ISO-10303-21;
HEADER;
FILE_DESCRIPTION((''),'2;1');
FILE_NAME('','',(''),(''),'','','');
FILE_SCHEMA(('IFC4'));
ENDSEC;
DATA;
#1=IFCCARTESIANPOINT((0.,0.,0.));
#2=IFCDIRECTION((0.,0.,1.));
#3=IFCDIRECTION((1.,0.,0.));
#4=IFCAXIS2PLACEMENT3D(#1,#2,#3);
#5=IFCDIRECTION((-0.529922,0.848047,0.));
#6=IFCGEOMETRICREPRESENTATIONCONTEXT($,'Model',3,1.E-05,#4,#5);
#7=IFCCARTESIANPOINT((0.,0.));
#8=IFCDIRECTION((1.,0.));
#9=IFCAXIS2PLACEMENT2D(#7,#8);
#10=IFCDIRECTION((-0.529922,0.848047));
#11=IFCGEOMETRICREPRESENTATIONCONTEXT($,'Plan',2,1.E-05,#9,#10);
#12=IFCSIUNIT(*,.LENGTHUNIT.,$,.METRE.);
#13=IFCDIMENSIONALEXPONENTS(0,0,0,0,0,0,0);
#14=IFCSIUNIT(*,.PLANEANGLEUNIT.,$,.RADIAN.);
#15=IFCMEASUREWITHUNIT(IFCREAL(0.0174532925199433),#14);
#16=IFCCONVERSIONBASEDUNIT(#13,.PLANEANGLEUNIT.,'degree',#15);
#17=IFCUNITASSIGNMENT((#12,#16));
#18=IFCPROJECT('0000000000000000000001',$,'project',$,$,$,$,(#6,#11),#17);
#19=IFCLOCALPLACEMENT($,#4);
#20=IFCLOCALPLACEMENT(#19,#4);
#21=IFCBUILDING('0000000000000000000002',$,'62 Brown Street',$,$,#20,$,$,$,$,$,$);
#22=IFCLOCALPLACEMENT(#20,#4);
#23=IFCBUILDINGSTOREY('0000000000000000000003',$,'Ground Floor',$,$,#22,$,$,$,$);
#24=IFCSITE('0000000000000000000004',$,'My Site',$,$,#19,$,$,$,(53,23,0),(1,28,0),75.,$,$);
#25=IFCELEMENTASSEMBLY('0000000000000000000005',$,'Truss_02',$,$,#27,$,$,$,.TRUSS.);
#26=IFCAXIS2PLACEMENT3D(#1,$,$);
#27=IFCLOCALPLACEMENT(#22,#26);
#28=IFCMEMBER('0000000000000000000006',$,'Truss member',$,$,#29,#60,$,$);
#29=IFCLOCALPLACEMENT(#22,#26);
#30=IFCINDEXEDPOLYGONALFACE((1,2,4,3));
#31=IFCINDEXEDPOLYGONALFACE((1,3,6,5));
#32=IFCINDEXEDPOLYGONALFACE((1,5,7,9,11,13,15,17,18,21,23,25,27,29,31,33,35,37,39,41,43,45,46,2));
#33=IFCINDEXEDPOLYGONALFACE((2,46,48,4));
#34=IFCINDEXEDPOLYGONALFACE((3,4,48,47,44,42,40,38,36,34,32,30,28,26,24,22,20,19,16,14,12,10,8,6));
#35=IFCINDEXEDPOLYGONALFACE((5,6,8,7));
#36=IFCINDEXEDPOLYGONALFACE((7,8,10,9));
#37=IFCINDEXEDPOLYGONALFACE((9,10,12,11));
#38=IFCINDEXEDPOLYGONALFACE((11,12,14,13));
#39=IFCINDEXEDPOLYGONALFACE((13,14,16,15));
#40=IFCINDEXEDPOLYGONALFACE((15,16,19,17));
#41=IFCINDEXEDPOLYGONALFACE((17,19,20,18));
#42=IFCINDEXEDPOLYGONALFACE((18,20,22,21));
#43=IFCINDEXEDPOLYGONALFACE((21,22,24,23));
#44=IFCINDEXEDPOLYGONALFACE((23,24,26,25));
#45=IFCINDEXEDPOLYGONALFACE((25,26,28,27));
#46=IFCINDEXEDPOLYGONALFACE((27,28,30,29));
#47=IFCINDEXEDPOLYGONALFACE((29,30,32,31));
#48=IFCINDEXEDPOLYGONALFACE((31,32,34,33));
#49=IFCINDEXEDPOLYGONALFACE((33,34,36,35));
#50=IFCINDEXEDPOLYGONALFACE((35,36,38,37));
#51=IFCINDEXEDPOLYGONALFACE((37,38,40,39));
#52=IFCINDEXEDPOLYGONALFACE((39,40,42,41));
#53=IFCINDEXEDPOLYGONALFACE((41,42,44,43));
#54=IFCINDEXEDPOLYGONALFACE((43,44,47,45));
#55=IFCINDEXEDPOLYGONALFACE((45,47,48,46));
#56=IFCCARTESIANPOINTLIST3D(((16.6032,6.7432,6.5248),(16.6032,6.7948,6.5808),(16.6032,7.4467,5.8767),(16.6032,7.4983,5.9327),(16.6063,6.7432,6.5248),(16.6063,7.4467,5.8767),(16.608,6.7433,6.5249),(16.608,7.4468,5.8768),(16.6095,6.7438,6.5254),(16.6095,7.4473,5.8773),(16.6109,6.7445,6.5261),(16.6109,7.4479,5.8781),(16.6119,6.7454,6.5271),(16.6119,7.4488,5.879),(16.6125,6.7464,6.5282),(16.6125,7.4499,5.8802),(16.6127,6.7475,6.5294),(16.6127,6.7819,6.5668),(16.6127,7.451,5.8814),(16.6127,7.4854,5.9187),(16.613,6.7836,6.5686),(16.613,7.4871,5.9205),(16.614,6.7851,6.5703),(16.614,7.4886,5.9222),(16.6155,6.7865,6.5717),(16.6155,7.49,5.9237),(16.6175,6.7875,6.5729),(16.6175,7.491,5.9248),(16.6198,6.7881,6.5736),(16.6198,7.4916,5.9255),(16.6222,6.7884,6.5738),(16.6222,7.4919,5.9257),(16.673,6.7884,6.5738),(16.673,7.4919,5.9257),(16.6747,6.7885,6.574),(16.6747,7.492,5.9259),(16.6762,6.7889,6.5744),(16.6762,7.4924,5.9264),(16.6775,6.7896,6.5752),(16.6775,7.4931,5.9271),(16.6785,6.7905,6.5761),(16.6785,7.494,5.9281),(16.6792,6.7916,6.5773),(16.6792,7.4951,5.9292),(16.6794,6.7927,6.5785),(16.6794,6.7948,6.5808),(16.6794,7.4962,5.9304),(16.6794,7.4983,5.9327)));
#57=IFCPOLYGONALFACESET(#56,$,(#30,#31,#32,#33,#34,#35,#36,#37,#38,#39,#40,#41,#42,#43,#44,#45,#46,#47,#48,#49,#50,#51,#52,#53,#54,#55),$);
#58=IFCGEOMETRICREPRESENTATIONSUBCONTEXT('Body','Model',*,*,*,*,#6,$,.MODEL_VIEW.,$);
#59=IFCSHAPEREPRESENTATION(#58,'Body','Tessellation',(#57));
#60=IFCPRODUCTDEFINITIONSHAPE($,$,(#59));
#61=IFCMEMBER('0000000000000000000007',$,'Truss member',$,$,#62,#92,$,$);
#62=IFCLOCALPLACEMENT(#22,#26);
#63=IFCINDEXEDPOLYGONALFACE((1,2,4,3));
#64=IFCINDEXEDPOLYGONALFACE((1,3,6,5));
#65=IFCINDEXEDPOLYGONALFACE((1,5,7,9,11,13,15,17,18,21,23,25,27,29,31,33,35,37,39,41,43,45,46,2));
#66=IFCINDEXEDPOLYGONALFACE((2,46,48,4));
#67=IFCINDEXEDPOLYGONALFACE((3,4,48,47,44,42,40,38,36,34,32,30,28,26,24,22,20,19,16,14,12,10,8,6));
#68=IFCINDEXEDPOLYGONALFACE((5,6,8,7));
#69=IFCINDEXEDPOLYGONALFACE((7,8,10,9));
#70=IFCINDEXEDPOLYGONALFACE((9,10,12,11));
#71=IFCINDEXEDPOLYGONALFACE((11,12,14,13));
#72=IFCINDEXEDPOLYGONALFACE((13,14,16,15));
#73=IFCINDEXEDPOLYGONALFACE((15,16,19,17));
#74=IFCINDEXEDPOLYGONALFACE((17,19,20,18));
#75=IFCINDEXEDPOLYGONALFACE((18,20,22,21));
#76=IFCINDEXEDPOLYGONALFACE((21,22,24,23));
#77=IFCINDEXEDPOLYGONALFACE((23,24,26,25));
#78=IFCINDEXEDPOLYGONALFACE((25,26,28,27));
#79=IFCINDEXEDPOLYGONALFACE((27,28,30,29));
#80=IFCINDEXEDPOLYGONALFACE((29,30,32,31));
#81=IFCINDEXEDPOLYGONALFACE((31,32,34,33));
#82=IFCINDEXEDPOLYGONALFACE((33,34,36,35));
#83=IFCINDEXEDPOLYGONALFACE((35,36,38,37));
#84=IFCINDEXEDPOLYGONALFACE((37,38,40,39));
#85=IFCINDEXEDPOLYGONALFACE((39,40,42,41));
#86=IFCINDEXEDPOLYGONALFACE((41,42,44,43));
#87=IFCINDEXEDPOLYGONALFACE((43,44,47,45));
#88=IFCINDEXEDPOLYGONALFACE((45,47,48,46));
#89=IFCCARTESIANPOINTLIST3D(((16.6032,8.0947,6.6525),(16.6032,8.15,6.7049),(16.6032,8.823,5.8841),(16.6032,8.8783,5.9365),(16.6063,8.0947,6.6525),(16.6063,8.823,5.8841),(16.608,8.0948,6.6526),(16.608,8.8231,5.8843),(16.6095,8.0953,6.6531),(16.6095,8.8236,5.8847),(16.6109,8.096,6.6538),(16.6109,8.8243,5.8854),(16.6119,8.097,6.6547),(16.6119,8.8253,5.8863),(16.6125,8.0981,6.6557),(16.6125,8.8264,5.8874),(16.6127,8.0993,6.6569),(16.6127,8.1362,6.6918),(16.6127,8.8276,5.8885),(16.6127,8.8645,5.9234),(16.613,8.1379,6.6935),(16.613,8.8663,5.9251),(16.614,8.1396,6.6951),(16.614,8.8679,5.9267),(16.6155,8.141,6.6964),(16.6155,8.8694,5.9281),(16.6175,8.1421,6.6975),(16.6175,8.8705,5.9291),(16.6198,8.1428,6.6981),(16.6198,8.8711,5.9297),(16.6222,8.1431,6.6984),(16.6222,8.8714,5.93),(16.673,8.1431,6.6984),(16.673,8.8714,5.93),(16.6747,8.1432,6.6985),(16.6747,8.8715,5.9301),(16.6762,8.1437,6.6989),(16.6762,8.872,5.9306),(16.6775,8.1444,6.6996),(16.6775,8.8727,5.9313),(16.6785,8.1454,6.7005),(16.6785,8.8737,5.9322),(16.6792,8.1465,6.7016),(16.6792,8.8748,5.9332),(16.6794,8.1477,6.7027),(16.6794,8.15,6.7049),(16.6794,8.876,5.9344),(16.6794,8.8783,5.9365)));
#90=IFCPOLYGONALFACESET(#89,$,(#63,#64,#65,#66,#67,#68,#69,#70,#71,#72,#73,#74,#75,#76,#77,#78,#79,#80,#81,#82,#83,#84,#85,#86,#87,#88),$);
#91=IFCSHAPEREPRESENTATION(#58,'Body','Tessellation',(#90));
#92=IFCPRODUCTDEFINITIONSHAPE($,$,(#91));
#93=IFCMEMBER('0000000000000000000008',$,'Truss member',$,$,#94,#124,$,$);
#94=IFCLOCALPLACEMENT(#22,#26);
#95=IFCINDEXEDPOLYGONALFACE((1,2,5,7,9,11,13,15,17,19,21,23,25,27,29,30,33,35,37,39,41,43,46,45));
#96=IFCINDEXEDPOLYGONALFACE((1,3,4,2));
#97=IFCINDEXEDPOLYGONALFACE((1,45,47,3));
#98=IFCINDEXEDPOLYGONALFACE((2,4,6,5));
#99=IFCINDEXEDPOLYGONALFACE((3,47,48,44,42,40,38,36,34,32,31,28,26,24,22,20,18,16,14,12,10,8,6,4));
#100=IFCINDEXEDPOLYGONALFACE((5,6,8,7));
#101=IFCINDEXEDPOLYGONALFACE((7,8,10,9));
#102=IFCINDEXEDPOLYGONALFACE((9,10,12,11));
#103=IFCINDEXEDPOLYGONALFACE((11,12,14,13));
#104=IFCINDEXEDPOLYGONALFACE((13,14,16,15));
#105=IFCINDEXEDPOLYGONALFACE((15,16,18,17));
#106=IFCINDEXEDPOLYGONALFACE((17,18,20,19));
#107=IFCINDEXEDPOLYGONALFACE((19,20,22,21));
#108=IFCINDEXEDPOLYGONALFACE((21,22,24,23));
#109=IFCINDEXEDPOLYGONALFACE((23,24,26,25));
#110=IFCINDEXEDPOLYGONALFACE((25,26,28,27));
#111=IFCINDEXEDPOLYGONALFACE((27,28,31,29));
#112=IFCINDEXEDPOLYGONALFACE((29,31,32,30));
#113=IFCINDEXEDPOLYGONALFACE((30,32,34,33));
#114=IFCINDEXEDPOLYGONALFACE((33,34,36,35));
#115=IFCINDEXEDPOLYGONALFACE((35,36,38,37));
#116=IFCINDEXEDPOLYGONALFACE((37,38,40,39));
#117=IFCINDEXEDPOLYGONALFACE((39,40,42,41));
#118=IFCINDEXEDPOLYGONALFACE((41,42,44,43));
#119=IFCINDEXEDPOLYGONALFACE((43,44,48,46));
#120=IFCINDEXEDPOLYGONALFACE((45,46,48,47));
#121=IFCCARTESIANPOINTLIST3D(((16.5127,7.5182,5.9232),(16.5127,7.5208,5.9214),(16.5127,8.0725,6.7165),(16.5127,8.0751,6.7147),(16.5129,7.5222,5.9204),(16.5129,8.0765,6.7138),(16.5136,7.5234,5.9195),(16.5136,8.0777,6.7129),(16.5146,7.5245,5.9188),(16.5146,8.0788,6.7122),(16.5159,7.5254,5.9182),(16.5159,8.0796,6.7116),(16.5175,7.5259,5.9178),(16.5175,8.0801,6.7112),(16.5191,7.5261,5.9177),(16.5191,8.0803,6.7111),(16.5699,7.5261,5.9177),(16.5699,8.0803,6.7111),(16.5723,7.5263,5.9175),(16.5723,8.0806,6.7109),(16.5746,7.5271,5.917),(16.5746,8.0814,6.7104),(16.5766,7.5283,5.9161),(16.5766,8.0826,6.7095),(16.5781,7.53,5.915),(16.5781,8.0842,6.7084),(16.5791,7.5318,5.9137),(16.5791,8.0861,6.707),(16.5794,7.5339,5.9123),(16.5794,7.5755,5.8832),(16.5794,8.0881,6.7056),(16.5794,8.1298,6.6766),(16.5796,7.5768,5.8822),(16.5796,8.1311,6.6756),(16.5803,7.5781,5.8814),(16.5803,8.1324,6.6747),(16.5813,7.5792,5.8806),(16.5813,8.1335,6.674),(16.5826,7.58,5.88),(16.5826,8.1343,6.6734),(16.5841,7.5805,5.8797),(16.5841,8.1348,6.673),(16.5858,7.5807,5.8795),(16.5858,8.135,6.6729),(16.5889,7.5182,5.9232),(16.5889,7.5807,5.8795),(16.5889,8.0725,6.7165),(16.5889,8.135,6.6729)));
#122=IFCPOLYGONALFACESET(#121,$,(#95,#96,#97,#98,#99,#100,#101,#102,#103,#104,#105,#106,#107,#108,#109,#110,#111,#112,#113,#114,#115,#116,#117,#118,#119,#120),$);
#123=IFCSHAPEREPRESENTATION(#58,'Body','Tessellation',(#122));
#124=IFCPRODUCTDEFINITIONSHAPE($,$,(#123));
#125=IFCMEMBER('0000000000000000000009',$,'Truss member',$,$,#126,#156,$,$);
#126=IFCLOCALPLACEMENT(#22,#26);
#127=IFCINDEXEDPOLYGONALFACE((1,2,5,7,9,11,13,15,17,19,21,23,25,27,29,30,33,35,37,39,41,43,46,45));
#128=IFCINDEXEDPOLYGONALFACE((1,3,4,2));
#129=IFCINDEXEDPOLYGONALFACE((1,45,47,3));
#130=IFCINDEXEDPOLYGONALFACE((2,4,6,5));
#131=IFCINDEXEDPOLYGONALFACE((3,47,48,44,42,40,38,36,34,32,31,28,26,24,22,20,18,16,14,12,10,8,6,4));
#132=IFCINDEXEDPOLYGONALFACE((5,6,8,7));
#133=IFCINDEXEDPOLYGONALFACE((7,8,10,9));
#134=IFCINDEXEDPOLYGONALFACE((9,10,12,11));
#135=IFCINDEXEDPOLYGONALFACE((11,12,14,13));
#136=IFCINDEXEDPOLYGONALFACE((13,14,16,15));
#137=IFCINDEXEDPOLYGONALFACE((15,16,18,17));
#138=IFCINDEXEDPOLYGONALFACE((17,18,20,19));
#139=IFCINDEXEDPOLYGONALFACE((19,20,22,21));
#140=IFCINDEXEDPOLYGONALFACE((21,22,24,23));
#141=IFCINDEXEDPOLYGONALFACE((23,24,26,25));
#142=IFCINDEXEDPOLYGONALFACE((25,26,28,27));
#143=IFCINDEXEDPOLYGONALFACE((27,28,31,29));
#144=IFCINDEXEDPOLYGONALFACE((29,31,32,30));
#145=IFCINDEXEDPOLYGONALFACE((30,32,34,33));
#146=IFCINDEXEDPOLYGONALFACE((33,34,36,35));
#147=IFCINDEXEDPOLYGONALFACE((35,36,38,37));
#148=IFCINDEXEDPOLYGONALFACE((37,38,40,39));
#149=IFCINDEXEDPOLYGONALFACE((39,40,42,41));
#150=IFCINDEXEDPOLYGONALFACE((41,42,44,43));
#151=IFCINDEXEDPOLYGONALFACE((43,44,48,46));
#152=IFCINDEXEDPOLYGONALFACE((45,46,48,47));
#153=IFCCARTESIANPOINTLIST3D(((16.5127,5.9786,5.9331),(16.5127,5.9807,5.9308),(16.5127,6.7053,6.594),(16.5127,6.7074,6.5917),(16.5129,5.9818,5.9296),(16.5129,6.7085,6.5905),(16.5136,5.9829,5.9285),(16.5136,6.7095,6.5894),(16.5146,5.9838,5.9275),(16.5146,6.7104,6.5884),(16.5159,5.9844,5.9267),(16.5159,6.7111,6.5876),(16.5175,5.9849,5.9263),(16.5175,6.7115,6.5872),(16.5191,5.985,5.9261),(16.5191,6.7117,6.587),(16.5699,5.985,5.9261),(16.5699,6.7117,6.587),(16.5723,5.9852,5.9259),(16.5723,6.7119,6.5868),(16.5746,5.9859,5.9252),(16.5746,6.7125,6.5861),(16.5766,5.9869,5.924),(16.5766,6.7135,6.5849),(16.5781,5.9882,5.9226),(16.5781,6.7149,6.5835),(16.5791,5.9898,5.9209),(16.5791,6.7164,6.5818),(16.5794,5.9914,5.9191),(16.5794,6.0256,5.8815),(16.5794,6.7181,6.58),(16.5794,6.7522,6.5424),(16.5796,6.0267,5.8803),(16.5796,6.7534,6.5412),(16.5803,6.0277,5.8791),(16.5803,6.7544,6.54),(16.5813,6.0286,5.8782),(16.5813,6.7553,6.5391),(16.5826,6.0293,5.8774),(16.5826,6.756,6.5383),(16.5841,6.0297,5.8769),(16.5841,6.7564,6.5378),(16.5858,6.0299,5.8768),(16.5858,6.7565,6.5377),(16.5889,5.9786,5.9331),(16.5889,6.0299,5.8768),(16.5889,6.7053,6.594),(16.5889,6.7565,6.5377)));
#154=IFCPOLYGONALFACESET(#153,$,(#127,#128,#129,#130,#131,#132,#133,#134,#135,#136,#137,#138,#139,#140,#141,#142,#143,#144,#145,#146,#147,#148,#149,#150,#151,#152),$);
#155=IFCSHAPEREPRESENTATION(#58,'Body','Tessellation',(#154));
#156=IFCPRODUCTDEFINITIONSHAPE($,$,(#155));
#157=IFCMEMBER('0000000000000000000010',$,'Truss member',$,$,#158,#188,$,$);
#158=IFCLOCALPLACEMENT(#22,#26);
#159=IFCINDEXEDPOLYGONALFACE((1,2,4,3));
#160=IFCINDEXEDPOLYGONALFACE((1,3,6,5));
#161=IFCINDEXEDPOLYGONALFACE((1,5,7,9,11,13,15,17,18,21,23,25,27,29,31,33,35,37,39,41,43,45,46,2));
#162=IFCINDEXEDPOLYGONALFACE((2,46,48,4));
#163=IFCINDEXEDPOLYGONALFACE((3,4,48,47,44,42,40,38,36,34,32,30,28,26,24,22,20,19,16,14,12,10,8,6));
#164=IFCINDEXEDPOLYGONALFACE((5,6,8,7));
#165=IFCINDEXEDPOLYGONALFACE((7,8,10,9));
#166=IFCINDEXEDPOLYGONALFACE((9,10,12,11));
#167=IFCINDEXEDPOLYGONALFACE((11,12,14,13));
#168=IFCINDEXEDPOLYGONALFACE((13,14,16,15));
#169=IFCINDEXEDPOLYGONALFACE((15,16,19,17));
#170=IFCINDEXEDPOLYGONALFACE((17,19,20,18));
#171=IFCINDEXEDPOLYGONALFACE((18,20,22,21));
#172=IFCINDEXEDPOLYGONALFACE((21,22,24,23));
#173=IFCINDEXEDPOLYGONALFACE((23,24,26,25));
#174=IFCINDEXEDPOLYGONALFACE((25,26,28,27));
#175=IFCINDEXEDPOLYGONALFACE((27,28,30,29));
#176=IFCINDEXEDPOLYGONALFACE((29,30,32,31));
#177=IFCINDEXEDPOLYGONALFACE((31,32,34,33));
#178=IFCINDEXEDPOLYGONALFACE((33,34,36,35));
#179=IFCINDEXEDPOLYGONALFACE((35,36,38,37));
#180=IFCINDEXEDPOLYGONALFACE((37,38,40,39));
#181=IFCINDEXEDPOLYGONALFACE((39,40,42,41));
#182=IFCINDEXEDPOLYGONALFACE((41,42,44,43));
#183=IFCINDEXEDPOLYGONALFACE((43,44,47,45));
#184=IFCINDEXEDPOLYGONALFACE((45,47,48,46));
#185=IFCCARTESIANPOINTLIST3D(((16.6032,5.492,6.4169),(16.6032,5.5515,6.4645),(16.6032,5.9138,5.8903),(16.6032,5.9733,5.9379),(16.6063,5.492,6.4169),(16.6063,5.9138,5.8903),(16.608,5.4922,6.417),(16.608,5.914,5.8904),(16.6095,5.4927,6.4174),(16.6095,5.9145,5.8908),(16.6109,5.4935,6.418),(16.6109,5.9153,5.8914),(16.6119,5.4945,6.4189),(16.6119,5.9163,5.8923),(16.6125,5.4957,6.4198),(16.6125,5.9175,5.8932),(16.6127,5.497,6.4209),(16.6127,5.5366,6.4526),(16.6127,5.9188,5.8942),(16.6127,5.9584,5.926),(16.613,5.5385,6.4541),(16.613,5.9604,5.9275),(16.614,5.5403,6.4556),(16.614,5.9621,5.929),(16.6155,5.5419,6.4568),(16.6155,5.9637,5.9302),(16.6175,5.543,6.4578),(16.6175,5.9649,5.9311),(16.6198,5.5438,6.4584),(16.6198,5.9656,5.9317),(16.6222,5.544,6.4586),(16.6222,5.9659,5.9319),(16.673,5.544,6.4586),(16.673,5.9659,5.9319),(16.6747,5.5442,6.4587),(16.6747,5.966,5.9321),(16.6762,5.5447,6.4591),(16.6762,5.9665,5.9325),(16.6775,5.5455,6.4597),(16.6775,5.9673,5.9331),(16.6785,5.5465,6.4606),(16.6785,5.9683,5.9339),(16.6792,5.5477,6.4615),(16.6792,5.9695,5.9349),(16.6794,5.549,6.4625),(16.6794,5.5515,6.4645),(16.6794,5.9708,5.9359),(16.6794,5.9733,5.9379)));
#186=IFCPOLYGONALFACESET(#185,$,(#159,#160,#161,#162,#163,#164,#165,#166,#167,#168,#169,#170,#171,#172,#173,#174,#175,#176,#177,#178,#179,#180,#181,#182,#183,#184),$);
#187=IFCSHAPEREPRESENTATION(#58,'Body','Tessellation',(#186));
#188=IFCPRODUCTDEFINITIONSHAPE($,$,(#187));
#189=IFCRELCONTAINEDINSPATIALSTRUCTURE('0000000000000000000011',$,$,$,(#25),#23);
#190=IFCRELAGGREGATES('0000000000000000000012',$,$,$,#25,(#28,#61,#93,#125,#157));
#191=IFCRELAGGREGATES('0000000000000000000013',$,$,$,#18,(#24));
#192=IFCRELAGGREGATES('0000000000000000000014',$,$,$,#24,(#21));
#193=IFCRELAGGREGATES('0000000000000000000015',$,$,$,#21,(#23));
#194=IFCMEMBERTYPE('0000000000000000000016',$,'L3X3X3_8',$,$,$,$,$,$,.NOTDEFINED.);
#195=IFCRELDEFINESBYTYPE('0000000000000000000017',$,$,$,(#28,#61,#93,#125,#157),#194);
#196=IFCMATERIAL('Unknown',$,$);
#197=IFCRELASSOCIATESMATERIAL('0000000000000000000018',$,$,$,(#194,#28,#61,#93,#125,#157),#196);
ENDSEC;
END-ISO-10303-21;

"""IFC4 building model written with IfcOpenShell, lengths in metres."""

from ifc_helpers import new_model, entity, si_unit, converted_unit, direction, frame, origin_with_axes, origin_2d_with_axis, place, context, subcontext, project, spatial, l_section, extrude, material, material_profile, profile_set, profile_usage, type_object, element, aggregate, save


model = new_model("IFC4")

# Units and contexts
model_context = context("Model", 3, precision=1e-05, world=origin_with_axes(), true_north=direction((-0.529922, 0.848047, 0.0)))
plan_context = context("Plan", 2, precision=1e-05, world=origin_2d_with_axis(), true_north=direction((-0.529922, 0.848047)))
body_context_1 = subcontext(model_context, "Body", "Model", "MODEL_VIEW")
ifc_project = project(units=[si_unit("LENGTHUNIT", "METRE"), converted_unit("PLANEANGLEUNIT", "degree", entity("IfcReal", 0.0174532925199433), si_unit("PLANEANGLEUNIT", "RADIAN"), dimensions=[0, 0, 0, 0, 0, 0, 0])], contexts=[model_context, plan_context])

# Site, building, storey
site_placement = place(None, origin_with_axes())
site = spatial("IfcSite", under=ifc_project, at=site_placement, Name="My Site", RefLatitude=(53, 23, 0), RefLongitude=(1, 28, 0), RefElevation=75.0)
building_placement = place(site_placement, origin_with_axes())
building = spatial("IfcBuilding", under=site, at=building_placement, Name="62 Brown Street")
storey_placement = place(building_placement, origin_with_axes())
storey = spatial("IfcBuildingStorey", under=building, at=storey_placement, Name="Ground Floor")

# Element assembly, members
ifc_material_1 = material(Name="Unknown")
ifc_material_profile_1 = material_profile(ifc_material_1, l_section(Depth=0.0762, Width=0.0762, Thickness=0.0095, FilletRadius=0.0095, EdgeRadius=0.0064))
ifc_profile_set_1 = profile_set([ifc_material_profile_1])
member_type_1 = type_object("IfcMemberType", Name="L3X3X3_8", PredefinedType="NOTDEFINED", material=ifc_profile_set_1)
assembly_1_placement = place(storey_placement, frame((16.6032, 10.4288, 6.9738), z_axis=(0.0, 0.0, 1.0), x_axis=(1.0, 0.0, 0.0)))
assembly_1 = element("IfcElementAssembly", 1, at=assembly_1_placement, inside=storey, Name="Truss_02", PredefinedType="TRUSS")
ifc_profile_usage_1 = profile_usage(ifc_profile_set_1, cardinal=5)
member_1_placement = place(assembly_1_placement, frame((0.0381, -3.6598, -0.421), z_axis=(-0.000001, 0.735484, -0.677542), x_axis=(1.0, 0.000001, 0.0)))
member_1 = element("IfcMember", 2, at=member_1_placement, type_object=member_type_1, material=ifc_profile_usage_1, Name="Truss member", context=body_context_1, shape_type="SweptSolid", body=[
    extrude(l_section(Depth=0.0762, Width=0.0762, Thickness=0.0095, FilletRadius=0.0095, EdgeRadius=0.0064), origin_with_axes(), (0.0, 0.0, 1.0), 0.9565),
])
ifc_profile_usage_2 = profile_usage(ifc_profile_set_1, cardinal=5)
member_2_placement = place(assembly_1_placement, frame((0.0381, -2.3065, -0.2951), z_axis=(-0.000001, 0.687927, -0.72578), x_axis=(1.0, 0.0, 0.0)))
member_2 = element("IfcMember", 3, at=member_2_placement, type_object=member_type_1, material=ifc_profile_usage_2, Name="Truss member", context=body_context_1, shape_type="SweptSolid", body=[
    extrude(l_section(Depth=0.0762, Width=0.0762, Thickness=0.0095, FilletRadius=0.0095, EdgeRadius=0.0064), origin_with_axes(), (0.0, 0.0, 1.0), 1.0587),
])
ifc_profile_usage_3 = profile_usage(ifc_profile_set_1, cardinal=5)
member_3_placement = place(assembly_1_placement, frame((-0.0524, -2.325, -0.279), z_axis=(0.000001, -0.572709, -0.819759), x_axis=(-1.0, -0.000001, 0.0)))
member_3 = element("IfcMember", 4, at=member_3_placement, type_object=member_type_1, material=ifc_profile_usage_3, Name="Truss member", context=body_context_1, shape_type="SweptSolid", body=[
    extrude(l_section(Depth=0.0762, Width=0.0762, Thickness=0.0095, FilletRadius=0.0095, EdgeRadius=0.0064), origin_with_axes(), (0.0, 0.0, 1.0), 0.9678),
])
ifc_profile_usage_4 = profile_usage(ifc_profile_set_1, cardinal=5)
member_4_placement = place(assembly_1_placement, frame((-0.0524, -3.6979, -0.4079), z_axis=(0.000001, -0.739785, -0.672843), x_axis=(-1.0, -0.000001, 0.0)))
member_4 = element("IfcMember", 5, at=member_4_placement, type_object=member_type_1, material=ifc_profile_usage_4, Name="Truss member", context=body_context_1, shape_type="SweptSolid", body=[
    extrude(l_section(Depth=0.0762, Width=0.0762, Thickness=0.0095, FilletRadius=0.0095, EdgeRadius=0.0064), origin_with_axes(), (0.0, 0.0, 1.0), 0.9823),
])
ifc_profile_usage_5 = profile_usage(ifc_profile_set_1, cardinal=5)
member_5_placement = place(assembly_1_placement, frame((0.0381, -4.907, -0.5331), z_axis=(-0.000001, 0.625169, -0.780489), x_axis=(1.0, 0.000001, 0.0)))
member_5 = element("IfcMember", 6, at=member_5_placement, type_object=member_type_1, material=ifc_profile_usage_5, Name="Truss member", context=body_context_1, shape_type="SweptSolid", body=[
    extrude(l_section(Depth=0.0762, Width=0.0762, Thickness=0.0095, FilletRadius=0.0095, EdgeRadius=0.0064), origin_with_axes(), (0.0, 0.0, 1.0), 0.6747),
])

aggregate(assembly_1, [member_1, member_2, member_3, member_4, member_5])

save(model, "model.ifc")
